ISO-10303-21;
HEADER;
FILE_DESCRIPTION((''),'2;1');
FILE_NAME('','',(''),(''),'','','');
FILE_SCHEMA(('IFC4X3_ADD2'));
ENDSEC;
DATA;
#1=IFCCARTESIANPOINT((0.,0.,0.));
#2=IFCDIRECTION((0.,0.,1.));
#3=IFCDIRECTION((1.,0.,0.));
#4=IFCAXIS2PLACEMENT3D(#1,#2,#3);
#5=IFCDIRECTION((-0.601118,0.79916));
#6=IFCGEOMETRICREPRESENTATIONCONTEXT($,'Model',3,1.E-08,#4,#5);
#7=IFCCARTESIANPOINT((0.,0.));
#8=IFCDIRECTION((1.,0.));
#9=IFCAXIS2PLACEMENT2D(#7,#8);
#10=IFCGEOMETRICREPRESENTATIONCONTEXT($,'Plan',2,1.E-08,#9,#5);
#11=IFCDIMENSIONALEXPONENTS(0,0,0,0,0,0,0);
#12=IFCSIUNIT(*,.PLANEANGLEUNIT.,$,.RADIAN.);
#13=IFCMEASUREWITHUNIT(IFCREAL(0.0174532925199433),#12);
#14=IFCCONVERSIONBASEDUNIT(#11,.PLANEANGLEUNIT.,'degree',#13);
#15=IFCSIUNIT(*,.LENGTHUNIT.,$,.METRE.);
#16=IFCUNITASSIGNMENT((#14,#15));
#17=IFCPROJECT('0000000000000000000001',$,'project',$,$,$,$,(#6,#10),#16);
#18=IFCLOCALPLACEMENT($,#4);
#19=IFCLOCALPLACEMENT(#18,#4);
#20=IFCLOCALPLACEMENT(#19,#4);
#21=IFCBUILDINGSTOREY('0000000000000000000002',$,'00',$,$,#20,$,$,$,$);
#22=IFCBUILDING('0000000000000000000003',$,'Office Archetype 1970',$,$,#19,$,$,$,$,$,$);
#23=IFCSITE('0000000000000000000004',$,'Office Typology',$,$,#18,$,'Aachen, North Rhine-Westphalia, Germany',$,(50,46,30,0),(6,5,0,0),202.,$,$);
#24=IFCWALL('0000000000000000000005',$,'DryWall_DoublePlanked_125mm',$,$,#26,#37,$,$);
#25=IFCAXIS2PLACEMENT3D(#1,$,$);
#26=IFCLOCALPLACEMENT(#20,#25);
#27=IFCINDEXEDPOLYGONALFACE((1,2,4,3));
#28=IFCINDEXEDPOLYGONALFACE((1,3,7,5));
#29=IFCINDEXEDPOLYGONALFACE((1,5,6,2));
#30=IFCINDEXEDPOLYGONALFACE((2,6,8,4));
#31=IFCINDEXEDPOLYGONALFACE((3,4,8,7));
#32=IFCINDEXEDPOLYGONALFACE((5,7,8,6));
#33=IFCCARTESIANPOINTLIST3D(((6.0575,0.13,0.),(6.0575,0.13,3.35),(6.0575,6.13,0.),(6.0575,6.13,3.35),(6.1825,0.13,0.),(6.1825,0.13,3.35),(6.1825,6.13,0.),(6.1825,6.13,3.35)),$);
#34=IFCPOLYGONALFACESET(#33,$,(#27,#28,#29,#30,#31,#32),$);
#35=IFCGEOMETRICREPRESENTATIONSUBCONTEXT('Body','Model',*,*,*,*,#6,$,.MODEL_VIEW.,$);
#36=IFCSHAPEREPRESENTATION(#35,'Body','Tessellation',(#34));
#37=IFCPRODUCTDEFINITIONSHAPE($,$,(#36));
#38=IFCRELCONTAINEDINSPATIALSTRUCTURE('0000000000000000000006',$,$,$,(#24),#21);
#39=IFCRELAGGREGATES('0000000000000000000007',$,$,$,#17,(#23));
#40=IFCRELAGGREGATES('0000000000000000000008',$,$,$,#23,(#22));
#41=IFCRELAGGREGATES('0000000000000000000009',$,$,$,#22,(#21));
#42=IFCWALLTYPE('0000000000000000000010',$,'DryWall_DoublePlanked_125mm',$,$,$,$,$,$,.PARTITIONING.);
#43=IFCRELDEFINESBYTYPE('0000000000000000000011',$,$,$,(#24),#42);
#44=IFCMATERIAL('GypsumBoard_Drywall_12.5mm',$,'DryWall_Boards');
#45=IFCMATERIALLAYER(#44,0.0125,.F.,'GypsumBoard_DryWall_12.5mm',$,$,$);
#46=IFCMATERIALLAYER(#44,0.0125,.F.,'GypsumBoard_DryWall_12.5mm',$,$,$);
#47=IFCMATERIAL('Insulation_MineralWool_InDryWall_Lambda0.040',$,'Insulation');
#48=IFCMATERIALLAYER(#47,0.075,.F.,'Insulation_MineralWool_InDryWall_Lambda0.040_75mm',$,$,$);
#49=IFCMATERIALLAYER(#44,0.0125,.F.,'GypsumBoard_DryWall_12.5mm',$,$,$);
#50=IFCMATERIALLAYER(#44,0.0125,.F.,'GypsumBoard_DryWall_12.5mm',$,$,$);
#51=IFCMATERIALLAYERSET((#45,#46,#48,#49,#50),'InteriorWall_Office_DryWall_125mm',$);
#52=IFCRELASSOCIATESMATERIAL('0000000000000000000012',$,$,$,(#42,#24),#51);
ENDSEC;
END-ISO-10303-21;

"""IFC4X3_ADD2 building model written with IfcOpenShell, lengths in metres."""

from ifc_helpers import new_model, entity, si_unit, converted_unit, direction, frame, origin_with_axes, origin_2d_with_axis, place, context, subcontext, project, spatial, line, indexed_curve, outline, extrude, material, layer, layer_set, layer_usage, type_object, element, save


model = new_model("IFC4X3_ADD2")

# Units and contexts
model_context = context("Model", 3, precision=1e-08, world=origin_with_axes(), true_north=direction((-0.601118, 0.79916)))
plan_context = context("Plan", 2, precision=1e-08, world=origin_2d_with_axis(), true_north=direction((-0.601118, 0.79916)))
body_context = subcontext(model_context, "Body", "Model", "MODEL_VIEW")
ifc_project = project(units=[converted_unit("PLANEANGLEUNIT", "degree", entity("IfcReal", 0.0174532925199433), si_unit("PLANEANGLEUNIT", "RADIAN"), dimensions=[0, 0, 0, 0, 0, 0, 0]), si_unit("LENGTHUNIT", "METRE")], contexts=[model_context, plan_context])

# Site, building, storey
site_placement = place(None, origin_with_axes())
site = spatial("IfcSite", under=ifc_project, at=site_placement, Name="Office Typology", LongName="Aachen, North Rhine-Westphalia, Germany", RefLatitude=(50, 46, 30, 0), RefLongitude=(6, 5, 0, 0), RefElevation=202.0)
building_placement = place(site_placement, origin_with_axes())
building = spatial("IfcBuilding", under=site, at=building_placement, Name="Office Archetype 1970")
storey_placement = place(building_placement, origin_with_axes())
storey = spatial("IfcBuildingStorey", under=building, at=storey_placement, Name="00")

# Wall
ifc_material_1 = material(Name="GypsumBoard_Drywall_12.5mm", Category="DryWall_Boards")
ifc_layer_1 = layer(ifc_material_1, 0.0125, ventilated=False, Name="GypsumBoard_DryWall_12.5mm")
ifc_layer_2 = layer(ifc_material_1, 0.0125, ventilated=False, Name="GypsumBoard_DryWall_12.5mm")
ifc_material_2 = material(Name="Insulation_MineralWool_InDryWall_Lambda0.040", Category="Insulation")
ifc_layer_3 = layer(ifc_material_2, 0.075, ventilated=False, Name="Insulation_MineralWool_InDryWall_Lambda0.040_75mm")
ifc_layer_4 = layer(ifc_material_1, 0.0125, ventilated=False, Name="GypsumBoard_DryWall_12.5mm")
ifc_layer_5 = layer(ifc_material_1, 0.0125, ventilated=False, Name="GypsumBoard_DryWall_12.5mm")
ifc_layer_set_1 = layer_set([ifc_layer_1, ifc_layer_2, ifc_layer_3, ifc_layer_4, ifc_layer_5], Name="InteriorWall_Office_DryWall_125mm")
ifc_layer_usage_1 = layer_usage(ifc_layer_set_1, "AXIS2", "POSITIVE", 0.0)
wall_type_1 = type_object("IfcWallType", Name="DryWall_DoublePlanked_125mm", PredefinedType="PARTITIONING", material=ifc_layer_set_1)
wall_1_placement = place(storey_placement, frame((6.0575, 6.13, 0.0), z_axis=(0.0, 0.0, 1.0), x_axis=(0.0, -1.0, 0.0)))
element("IfcWall", 1, at=wall_1_placement, inside=storey, type_object=wall_type_1, material=ifc_layer_usage_1, Name="DryWall_DoublePlanked_125mm", context=body_context, shape_type="SweptSolid", body=[
    extrude(outline(indexed_curve([(0.0, 0.0), (0.0, 0.125), (6.0, 0.125), (6.0, 0.0)], segments=[line(1, 2, 3, 4, 1)])), origin_with_axes(), (0.0, 0.0, 1.0), 3.35),
])

save(model, "model.ifc")
